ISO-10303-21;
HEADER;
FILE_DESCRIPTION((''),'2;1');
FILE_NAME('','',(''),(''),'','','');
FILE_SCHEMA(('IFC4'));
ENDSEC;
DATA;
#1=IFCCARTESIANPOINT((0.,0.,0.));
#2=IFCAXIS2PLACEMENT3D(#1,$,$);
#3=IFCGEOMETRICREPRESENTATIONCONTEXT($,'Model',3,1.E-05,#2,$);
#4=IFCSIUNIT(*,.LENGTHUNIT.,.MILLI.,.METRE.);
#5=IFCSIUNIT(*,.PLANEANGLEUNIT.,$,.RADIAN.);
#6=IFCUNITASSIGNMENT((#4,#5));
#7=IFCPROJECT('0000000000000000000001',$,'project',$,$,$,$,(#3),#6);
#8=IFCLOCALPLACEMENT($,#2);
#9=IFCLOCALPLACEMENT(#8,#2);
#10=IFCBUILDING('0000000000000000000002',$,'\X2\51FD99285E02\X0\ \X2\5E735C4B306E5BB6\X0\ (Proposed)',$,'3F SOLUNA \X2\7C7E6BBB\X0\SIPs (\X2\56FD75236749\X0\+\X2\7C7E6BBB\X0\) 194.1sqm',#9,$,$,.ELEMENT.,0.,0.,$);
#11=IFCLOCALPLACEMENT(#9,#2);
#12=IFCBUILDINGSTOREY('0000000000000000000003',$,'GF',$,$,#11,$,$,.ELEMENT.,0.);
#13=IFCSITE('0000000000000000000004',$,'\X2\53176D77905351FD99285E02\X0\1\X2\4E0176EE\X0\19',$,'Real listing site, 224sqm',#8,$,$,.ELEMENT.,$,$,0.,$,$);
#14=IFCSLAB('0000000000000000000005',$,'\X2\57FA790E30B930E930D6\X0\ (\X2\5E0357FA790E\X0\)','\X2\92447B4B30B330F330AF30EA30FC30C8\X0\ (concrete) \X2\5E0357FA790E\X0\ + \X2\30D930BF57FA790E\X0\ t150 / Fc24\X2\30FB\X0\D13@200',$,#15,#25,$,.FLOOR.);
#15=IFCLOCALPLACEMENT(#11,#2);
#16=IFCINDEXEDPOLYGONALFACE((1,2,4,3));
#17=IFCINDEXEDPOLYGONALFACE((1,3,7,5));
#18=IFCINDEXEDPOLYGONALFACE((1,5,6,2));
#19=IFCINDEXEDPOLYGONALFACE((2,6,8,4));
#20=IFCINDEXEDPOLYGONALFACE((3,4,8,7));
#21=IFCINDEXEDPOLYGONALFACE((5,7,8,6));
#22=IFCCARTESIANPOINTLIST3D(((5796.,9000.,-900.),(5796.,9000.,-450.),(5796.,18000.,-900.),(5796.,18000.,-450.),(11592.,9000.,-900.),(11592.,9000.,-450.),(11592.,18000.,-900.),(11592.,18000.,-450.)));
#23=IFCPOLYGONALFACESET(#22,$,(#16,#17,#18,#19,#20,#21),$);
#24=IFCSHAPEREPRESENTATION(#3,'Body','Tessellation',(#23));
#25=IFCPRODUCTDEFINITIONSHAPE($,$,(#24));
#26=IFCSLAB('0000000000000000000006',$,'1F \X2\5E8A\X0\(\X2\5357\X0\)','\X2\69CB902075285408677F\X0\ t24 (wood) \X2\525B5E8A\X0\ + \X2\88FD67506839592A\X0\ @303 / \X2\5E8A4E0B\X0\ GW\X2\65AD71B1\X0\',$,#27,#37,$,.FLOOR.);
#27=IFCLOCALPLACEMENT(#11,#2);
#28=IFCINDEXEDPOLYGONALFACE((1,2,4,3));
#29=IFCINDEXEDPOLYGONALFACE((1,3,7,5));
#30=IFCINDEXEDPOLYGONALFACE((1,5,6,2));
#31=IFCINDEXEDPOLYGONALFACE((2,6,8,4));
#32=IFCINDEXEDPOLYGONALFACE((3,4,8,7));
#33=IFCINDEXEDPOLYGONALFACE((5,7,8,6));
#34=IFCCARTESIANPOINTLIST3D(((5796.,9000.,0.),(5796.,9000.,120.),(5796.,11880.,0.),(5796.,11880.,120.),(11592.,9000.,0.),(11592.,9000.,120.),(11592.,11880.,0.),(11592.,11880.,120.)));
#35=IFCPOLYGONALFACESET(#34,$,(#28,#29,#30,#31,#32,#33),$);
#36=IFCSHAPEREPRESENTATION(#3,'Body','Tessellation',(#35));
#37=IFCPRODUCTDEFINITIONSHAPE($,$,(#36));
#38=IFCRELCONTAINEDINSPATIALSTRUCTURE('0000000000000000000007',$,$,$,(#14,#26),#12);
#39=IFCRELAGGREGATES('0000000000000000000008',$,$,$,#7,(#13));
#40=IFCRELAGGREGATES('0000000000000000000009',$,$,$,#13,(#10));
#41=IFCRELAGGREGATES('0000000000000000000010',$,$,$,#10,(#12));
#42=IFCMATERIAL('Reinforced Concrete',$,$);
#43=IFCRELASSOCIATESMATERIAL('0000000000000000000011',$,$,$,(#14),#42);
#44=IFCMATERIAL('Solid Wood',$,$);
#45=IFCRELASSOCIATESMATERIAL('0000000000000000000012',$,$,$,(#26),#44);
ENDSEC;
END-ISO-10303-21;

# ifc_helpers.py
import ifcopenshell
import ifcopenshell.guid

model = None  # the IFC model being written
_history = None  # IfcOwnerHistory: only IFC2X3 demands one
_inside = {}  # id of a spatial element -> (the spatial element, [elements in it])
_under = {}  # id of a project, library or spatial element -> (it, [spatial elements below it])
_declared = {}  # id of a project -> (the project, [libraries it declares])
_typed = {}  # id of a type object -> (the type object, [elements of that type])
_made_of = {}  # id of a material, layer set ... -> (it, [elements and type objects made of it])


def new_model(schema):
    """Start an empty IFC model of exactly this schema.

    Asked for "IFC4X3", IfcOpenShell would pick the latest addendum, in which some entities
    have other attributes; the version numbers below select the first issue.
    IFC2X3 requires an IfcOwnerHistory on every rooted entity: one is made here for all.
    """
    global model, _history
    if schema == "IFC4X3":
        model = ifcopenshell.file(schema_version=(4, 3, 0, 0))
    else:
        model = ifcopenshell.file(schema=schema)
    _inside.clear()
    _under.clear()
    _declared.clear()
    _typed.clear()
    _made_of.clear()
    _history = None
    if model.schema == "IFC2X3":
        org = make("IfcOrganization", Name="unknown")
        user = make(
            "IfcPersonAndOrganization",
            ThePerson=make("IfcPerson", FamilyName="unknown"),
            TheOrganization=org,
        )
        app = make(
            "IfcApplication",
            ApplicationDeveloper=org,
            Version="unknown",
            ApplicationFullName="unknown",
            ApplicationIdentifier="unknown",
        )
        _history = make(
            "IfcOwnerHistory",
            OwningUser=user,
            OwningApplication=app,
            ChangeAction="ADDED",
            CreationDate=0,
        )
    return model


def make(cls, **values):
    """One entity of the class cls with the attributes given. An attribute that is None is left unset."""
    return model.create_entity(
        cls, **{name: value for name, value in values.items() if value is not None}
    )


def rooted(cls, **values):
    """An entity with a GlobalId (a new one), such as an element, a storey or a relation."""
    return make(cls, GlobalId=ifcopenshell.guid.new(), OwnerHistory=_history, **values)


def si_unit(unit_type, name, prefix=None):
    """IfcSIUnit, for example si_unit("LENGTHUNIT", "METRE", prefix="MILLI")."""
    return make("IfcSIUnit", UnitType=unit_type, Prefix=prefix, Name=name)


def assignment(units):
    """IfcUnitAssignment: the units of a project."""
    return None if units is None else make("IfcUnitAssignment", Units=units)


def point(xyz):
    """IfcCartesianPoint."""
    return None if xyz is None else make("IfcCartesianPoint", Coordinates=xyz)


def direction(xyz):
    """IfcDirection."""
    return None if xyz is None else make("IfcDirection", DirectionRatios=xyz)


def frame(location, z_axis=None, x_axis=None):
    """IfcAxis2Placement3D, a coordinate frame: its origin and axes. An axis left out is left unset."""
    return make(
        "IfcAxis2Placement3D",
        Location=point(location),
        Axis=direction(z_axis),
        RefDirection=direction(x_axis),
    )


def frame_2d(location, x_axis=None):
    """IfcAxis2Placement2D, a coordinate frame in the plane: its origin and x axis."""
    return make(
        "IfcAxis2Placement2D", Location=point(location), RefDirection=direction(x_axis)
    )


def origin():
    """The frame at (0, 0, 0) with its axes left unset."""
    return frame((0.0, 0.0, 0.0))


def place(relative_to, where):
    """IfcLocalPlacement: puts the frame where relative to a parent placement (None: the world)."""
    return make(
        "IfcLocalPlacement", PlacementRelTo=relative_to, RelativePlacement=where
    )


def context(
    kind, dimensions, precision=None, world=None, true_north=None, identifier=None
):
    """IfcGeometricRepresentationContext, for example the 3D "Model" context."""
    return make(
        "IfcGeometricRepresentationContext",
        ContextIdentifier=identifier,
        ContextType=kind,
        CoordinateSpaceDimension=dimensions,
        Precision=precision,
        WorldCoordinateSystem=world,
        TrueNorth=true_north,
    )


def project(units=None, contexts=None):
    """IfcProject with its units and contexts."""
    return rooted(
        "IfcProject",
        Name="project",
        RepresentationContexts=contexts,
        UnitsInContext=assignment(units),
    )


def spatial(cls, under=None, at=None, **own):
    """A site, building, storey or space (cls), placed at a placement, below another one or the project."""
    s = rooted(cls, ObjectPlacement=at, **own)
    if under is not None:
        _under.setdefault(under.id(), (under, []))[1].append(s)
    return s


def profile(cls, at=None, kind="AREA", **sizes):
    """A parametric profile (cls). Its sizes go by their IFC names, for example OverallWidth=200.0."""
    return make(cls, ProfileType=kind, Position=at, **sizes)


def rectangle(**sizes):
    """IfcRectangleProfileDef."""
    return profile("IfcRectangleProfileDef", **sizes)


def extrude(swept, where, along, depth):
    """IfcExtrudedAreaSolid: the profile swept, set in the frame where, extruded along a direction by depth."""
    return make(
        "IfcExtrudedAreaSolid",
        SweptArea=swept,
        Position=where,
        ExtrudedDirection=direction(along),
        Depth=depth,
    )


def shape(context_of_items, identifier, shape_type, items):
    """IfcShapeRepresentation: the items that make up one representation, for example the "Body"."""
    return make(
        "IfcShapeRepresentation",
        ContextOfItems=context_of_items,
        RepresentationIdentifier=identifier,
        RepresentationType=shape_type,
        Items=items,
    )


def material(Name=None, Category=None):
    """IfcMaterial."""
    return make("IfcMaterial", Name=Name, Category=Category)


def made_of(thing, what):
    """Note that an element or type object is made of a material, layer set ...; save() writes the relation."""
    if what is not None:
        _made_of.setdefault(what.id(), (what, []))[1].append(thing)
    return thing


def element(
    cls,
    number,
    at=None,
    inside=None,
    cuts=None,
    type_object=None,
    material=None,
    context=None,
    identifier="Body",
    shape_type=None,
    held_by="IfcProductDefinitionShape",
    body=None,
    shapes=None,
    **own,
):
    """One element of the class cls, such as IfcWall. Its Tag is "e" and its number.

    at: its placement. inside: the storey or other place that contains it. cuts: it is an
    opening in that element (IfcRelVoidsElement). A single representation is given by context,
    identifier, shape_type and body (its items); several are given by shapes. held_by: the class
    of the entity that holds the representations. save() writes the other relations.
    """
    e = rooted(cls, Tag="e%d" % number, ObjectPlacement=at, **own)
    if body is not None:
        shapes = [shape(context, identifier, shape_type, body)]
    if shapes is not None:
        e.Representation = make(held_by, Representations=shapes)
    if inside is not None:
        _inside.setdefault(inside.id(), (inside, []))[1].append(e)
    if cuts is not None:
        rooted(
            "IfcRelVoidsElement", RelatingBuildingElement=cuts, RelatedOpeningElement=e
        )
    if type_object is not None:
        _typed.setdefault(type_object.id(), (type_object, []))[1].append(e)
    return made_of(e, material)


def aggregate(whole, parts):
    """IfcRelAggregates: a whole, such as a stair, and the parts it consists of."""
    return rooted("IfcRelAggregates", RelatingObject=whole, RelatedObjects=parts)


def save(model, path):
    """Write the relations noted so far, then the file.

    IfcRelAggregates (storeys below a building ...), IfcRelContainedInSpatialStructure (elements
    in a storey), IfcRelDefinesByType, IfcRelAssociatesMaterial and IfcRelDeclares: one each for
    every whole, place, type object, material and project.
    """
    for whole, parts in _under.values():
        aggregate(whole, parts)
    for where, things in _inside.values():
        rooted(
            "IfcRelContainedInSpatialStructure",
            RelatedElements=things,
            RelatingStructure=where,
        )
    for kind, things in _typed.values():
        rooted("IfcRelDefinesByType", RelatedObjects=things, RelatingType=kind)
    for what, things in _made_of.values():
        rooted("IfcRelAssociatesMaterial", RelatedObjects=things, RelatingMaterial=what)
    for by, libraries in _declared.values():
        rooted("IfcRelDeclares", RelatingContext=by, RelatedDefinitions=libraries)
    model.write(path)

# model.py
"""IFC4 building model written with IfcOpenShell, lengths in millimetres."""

from ifc_helpers import new_model, si_unit, frame, frame_2d, origin, place, context, project, spatial, rectangle, extrude, material, element, save


model = new_model("IFC4")

# Units and contexts
model_context = context("Model", 3, precision=1e-05, world=origin())
ifc_project = project(units=[si_unit("LENGTHUNIT", "METRE", prefix="MILLI"), si_unit("PLANEANGLEUNIT", "RADIAN")], contexts=[model_context])

# Site, building, storey
site_placement = place(None, origin())
site = spatial("IfcSite", under=ifc_project, at=site_placement, Name="北海道函館市1丁目19", ObjectType="Real listing site, 224sqm", CompositionType="ELEMENT", RefElevation=0.0)
building_placement = place(site_placement, origin())
building = spatial("IfcBuilding", under=site, at=building_placement, Name="函館市 平屋の家 (Proposed)", ObjectType="3F SOLUNA 籾殻SIPs (国産杉+籾殻) 194.1sqm", CompositionType="ELEMENT", ElevationOfRefHeight=0.0, ElevationOfTerrain=0.0)
storey_placement = place(building_placement, origin())
storey = spatial("IfcBuildingStorey", under=building, at=storey_placement, Name="GF", CompositionType="ELEMENT", Elevation=0.0)

# Slabs
ifc_material_1 = material(Name="Reinforced Concrete")
slab_1_placement = place(storey_placement, frame((2898.0, 4500.0, -450.0)))
element("IfcSlab", 1, at=slab_1_placement, inside=storey, material=ifc_material_1, Name="基礎スラブ (布基礎)", Description="鉄筋コンクリート (concrete) 布基礎 + ベタ基礎 t150 / Fc24・D13@200", PredefinedType="FLOOR", context=model_context, shape_type="SweptSolid", body=[
    extrude(rectangle(XDim=5796.0, YDim=9000.0, at=frame_2d((2898.0, 4500.0))), frame((2898.0, 4500.0, -450.0)), (0.0, 0.0, 1.0), 450.0),
])
ifc_material_2 = material(Name="Solid Wood")
slab_2_placement = place(storey_placement, frame((2898.0, 4500.0, 0.0)))
element("IfcSlab", 2, at=slab_2_placement, inside=storey, material=ifc_material_2, Name="1F 床(南)", Description="構造用合板 t24 (wood) 剛床 + 製材根太 @303 / 床下 GW断熱", PredefinedType="FLOOR", context=model_context, shape_type="SweptSolid", body=[
    extrude(rectangle(XDim=5796.0, YDim=2880.0, at=frame_2d((2898.0, 1440.0))), frame((2898.0, 4500.0, 0.0)), (0.0, 0.0, 1.0), 120.0),
])

save(model, "model.ifc")
